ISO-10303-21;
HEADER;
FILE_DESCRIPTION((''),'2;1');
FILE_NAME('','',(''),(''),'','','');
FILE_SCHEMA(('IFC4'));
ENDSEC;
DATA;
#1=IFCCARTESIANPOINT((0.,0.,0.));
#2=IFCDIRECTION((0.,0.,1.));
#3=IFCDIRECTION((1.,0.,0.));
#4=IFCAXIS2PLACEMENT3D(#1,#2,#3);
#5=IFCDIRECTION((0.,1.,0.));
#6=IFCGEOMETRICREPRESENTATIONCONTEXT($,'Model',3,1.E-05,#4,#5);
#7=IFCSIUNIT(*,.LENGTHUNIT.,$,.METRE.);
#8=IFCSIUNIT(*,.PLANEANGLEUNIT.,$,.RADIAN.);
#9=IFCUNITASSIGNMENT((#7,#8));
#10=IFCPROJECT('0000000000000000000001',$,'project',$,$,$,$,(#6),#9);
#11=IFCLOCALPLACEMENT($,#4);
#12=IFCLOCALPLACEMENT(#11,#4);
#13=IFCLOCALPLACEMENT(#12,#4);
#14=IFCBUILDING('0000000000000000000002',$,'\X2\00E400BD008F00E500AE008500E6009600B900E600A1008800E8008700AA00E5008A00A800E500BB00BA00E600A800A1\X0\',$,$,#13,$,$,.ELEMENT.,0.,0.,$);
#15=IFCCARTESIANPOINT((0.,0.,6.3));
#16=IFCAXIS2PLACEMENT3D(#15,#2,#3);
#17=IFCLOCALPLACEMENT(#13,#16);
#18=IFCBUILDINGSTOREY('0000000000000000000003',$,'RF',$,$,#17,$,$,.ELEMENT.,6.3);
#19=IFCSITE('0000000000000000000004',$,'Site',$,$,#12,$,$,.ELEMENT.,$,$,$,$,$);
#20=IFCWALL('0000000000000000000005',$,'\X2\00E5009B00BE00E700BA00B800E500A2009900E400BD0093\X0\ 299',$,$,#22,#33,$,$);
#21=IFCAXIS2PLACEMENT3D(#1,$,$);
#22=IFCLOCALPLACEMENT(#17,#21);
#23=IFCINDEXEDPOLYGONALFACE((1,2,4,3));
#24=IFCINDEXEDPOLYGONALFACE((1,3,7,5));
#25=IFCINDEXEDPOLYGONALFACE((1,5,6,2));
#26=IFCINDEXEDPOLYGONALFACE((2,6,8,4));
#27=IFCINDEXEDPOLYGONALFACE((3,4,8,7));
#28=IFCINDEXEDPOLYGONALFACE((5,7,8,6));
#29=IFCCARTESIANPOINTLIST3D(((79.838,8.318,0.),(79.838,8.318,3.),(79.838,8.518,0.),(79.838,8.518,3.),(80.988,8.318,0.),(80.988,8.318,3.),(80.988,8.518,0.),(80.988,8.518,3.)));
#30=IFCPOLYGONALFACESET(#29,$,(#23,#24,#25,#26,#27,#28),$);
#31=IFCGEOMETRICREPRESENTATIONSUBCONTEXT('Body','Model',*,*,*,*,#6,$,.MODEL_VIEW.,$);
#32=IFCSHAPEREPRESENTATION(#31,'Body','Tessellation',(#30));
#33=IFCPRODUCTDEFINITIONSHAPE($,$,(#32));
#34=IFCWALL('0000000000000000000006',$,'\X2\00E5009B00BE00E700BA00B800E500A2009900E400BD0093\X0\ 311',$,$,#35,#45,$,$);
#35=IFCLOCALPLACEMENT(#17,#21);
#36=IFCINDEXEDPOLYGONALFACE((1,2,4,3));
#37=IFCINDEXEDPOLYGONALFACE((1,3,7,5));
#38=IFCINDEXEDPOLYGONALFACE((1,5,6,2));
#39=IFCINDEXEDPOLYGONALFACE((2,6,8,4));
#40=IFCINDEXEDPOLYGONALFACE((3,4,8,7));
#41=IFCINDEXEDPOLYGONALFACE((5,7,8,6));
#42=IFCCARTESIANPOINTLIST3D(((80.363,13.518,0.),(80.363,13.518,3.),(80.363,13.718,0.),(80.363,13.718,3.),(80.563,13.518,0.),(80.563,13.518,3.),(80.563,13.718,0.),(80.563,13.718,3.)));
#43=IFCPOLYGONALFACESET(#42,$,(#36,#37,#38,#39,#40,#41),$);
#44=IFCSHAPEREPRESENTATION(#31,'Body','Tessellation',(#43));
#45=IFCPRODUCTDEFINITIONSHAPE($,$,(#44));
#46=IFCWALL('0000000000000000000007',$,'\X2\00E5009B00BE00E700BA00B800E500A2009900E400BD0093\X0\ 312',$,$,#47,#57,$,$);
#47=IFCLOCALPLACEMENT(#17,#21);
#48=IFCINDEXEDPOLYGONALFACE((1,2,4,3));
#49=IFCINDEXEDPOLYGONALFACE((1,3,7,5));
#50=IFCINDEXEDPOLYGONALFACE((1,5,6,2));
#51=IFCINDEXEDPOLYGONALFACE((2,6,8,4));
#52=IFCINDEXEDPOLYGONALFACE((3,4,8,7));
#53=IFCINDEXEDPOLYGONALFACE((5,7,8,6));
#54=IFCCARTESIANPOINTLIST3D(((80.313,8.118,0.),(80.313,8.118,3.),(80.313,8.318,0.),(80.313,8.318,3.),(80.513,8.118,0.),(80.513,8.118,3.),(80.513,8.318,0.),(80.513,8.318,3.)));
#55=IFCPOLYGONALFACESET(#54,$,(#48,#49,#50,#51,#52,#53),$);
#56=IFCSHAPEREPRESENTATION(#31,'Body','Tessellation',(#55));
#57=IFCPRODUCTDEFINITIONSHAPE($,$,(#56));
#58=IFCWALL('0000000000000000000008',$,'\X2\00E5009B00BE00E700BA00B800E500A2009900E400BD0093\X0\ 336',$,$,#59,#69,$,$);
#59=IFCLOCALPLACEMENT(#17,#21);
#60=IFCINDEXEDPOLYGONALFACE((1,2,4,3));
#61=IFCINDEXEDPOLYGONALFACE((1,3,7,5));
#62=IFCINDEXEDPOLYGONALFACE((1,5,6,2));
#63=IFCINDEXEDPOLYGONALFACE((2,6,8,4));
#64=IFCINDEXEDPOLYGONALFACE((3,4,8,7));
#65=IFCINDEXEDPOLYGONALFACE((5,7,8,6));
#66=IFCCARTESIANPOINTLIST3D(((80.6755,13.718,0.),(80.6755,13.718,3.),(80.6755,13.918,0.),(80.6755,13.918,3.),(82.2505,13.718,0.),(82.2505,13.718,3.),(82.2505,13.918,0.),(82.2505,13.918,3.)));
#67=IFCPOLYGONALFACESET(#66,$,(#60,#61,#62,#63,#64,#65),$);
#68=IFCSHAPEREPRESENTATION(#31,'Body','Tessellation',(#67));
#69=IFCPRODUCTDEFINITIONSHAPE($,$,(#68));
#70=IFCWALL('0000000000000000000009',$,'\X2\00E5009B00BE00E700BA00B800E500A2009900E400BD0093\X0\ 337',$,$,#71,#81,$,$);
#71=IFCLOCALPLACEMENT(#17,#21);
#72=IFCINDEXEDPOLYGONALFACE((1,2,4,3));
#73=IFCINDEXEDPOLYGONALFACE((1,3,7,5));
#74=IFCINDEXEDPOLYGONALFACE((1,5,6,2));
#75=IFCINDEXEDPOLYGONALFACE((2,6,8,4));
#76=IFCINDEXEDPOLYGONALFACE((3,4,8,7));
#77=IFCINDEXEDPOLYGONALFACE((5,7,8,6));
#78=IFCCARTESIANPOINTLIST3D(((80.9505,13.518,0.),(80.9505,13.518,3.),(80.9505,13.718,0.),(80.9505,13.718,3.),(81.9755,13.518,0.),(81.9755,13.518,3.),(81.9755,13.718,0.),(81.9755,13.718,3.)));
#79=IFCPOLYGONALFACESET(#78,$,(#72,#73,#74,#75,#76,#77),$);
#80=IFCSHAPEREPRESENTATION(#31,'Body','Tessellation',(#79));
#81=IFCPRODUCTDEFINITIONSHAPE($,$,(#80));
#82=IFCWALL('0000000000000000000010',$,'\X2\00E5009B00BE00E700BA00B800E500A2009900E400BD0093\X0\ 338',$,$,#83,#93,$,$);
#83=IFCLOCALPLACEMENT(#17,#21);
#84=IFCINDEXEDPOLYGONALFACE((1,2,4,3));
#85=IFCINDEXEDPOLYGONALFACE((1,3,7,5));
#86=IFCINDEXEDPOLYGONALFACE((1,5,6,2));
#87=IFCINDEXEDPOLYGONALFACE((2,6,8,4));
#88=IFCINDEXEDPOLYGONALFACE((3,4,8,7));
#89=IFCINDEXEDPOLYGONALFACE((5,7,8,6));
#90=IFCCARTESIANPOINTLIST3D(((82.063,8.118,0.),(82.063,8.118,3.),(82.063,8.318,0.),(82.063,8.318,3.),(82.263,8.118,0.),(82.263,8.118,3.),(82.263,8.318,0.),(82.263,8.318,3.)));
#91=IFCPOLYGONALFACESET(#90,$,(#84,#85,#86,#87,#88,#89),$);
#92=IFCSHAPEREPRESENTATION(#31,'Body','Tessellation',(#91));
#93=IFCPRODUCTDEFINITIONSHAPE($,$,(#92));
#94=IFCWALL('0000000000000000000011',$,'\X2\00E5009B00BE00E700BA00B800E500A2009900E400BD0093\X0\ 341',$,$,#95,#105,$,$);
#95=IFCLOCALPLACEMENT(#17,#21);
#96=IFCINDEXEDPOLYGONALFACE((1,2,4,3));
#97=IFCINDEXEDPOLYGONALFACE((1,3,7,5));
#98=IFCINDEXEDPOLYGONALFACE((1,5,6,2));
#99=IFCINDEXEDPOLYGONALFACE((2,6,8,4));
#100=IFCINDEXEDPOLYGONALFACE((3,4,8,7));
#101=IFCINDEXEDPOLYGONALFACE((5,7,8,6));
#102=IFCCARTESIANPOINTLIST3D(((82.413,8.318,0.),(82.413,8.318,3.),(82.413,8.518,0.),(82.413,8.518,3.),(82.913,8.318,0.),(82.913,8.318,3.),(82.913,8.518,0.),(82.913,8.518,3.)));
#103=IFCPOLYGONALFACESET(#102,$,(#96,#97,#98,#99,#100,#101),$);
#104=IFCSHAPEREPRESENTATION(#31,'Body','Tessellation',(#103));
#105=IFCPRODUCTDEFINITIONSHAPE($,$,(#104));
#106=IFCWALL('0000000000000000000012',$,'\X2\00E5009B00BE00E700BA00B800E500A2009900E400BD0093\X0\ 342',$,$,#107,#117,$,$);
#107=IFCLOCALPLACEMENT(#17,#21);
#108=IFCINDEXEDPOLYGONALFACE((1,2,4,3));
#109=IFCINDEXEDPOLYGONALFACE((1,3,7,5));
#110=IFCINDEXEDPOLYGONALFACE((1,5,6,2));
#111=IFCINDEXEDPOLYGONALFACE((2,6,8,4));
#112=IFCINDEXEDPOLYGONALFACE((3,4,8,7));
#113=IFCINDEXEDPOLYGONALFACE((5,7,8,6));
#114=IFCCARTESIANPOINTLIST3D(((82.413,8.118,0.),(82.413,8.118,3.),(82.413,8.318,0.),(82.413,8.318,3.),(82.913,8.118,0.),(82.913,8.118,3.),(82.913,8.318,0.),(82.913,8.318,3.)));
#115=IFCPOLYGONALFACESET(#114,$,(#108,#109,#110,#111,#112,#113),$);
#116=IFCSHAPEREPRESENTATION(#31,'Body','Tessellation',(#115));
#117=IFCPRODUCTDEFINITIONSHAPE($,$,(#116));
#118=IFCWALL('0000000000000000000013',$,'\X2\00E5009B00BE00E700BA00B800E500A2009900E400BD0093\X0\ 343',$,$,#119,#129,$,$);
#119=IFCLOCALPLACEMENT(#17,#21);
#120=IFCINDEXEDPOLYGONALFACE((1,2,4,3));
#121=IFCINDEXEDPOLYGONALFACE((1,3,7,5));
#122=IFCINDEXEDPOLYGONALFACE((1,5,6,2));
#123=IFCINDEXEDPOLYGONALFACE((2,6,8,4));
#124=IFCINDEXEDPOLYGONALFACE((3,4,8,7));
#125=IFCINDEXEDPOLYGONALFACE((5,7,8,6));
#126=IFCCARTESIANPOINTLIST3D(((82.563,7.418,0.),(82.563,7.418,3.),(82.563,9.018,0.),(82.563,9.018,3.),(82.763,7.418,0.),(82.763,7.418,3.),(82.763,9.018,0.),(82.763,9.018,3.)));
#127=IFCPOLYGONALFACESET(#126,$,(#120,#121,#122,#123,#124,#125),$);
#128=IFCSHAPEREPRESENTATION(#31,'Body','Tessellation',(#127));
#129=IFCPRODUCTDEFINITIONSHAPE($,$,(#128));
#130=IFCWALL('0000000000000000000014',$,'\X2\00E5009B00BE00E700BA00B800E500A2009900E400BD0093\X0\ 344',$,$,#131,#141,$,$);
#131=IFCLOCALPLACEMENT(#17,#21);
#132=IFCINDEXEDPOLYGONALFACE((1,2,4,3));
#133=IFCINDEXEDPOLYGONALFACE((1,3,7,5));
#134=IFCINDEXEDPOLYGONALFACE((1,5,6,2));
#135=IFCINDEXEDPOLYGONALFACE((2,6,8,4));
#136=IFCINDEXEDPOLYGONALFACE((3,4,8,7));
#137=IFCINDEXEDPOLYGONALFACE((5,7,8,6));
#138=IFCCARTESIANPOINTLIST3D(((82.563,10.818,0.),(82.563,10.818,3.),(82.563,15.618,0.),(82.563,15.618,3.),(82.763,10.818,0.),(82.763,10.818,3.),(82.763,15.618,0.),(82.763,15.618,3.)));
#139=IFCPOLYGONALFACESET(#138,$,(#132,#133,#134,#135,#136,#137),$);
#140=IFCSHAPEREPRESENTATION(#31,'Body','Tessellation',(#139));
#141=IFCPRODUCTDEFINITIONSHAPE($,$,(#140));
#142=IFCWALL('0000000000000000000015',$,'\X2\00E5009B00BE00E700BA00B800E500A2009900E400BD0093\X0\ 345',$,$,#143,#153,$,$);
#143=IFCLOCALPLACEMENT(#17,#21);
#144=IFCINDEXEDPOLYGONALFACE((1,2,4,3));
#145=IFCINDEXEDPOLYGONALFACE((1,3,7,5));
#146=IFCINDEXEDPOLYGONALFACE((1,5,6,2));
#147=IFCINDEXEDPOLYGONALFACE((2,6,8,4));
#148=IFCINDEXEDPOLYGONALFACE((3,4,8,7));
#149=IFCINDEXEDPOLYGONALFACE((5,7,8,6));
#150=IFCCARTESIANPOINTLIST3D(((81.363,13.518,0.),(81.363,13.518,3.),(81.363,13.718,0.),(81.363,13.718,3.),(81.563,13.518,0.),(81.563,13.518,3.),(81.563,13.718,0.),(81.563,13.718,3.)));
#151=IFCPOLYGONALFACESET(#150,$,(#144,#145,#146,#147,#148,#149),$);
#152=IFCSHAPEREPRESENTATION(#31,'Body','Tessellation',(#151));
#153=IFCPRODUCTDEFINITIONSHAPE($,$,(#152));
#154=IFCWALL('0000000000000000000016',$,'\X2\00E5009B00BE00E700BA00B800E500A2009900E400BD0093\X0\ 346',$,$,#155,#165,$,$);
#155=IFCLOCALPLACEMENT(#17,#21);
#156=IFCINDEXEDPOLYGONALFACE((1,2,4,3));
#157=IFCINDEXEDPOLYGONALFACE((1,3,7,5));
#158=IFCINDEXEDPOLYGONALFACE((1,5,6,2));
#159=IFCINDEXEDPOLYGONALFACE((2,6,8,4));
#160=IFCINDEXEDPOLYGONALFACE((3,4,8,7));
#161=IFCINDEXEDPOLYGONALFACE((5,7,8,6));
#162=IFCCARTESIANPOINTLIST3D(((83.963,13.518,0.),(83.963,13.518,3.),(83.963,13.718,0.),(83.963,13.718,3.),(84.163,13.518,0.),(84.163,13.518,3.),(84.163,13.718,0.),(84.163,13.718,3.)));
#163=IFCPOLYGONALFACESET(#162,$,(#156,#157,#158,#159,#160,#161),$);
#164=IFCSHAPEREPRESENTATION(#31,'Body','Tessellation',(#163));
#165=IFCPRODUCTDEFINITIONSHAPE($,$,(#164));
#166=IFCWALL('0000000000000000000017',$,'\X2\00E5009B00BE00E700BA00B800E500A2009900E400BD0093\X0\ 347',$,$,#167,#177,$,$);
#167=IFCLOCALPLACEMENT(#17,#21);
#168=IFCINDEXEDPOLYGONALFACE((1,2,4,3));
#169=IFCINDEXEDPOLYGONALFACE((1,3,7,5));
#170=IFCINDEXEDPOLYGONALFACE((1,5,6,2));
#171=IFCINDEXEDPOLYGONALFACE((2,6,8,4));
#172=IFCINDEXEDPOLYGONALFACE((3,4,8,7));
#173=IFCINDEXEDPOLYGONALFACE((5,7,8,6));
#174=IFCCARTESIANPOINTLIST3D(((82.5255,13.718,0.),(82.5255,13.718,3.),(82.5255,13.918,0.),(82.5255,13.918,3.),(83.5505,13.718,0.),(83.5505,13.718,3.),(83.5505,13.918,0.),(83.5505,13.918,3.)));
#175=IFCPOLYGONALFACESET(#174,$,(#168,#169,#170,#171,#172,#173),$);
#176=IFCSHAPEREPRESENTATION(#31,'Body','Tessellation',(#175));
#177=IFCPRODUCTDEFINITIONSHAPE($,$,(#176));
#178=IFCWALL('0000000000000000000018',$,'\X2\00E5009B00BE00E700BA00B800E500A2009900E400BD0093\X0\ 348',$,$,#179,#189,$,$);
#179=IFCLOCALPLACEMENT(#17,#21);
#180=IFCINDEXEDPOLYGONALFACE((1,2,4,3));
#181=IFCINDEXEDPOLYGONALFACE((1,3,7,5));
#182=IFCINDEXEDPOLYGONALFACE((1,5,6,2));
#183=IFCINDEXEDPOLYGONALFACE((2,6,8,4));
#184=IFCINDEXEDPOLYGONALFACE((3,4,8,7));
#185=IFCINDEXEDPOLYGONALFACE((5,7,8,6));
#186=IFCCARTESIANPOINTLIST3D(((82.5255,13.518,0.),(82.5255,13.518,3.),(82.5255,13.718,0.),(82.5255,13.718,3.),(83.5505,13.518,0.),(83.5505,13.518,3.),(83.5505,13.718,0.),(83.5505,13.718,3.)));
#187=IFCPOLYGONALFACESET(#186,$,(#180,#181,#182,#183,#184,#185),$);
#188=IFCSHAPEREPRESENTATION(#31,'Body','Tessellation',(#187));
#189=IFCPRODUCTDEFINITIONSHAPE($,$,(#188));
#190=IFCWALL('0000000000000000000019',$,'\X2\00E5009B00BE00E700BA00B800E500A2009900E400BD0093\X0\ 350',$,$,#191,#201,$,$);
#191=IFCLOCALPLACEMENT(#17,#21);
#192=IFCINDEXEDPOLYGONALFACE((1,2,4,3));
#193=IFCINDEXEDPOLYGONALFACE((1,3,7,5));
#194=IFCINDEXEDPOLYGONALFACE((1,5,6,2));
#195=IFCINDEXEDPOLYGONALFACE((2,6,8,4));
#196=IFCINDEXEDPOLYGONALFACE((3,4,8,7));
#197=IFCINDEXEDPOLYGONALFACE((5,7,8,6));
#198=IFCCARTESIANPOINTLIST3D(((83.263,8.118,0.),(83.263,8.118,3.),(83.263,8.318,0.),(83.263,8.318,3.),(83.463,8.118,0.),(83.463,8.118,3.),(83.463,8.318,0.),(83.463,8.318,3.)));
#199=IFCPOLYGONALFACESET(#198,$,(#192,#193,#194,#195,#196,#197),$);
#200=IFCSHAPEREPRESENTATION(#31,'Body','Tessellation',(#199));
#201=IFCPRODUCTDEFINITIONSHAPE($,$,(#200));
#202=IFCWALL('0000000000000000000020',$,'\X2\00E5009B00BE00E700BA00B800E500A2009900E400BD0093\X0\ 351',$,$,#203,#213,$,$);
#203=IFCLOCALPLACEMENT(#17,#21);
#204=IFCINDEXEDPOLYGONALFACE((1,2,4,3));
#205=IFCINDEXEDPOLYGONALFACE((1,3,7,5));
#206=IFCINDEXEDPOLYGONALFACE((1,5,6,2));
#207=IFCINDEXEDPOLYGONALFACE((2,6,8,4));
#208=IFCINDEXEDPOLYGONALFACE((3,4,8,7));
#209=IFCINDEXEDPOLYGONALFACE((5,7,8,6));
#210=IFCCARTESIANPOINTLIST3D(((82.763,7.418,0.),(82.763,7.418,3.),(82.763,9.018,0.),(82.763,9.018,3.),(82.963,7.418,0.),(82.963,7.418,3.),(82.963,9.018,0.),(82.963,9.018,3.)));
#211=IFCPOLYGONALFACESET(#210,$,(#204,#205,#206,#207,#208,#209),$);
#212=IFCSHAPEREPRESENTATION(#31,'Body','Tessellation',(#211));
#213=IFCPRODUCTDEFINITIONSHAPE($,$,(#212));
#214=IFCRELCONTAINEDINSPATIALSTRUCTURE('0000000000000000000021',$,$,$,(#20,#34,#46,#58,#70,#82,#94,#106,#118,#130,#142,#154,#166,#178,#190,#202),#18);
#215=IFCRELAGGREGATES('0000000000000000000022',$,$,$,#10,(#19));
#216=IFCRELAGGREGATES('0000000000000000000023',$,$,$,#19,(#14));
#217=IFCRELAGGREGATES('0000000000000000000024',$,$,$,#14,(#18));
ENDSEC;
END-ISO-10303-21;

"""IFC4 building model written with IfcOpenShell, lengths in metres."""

from ifc_helpers import new_model, si_unit, direction, frame, frame_2d, origin_with_axes, place, context, subcontext, project, spatial, rectangle, extrude, element, save


model = new_model("IFC4")

# Units and contexts
model_context = context("Model", 3, precision=1e-05, world=origin_with_axes(), true_north=direction((0.0, 1.0, 0.0)))
body_context = subcontext(model_context, "Body", "Model", "MODEL_VIEW")
ifc_project = project(units=[si_unit("LENGTHUNIT", "METRE"), si_unit("PLANEANGLEUNIT", "RADIAN")], contexts=[model_context])

# Site, building, storey
placement = place(None, origin_with_axes())
site_placement = place(placement, origin_with_axes())
site = spatial("IfcSite", under=ifc_project, at=site_placement, Name="Site", CompositionType="ELEMENT")
building_placement = place(site_placement, origin_with_axes())
building = spatial("IfcBuilding", under=site, at=building_placement, Name="ä½\u008få®\u0085æ\u0096¹æ¡\u0088è\u0087ªå\u008a¨å»ºæ¨¡", CompositionType="ELEMENT", ElevationOfRefHeight=0.0, ElevationOfTerrain=0.0)
storey_placement = place(building_placement, frame((0.0, 0.0, 6.3), z_axis=(0.0, 0.0, 1.0), x_axis=(1.0, 0.0, 0.0)))
storey = spatial("IfcBuildingStorey", under=building, at=storey_placement, Name="RF", CompositionType="ELEMENT", Elevation=6.3)

# Walls
wall_1_placement = place(storey_placement, frame((80.413, 8.418, 0.0), z_axis=(0.0, 0.0, 1.0), x_axis=(-1.0, 0.0, 0.0)))
element("IfcWall", 1, at=wall_1_placement, inside=storey, Name="å\u009b¾çº¸å¢\u0099ä½\u0093 299", context=body_context, shape_type="SweptSolid", body=[
    extrude(rectangle(XDim=1.15, YDim=0.2, at=frame_2d((0.0, 0.0), x_axis=(1.0, 0.0, 0.0))), frame((0.0, 0.0, 0.0), z_axis=(0.0, 0.0, 1.0)), (0.0, 0.0, 1.0), 3.0),
])
for number, where, z_axis, x_axis, name in (
    (2, (80.463, 13.618, 0.0), (0.0, 0.0, 1.0), (0.0, 1.0, 0.0), "å\u009b¾çº¸å¢\u0099ä½\u0093 311"),
    (3, (80.413, 8.218, 0.0), (0.0, 0.0, 1.0), (0.0, 1.0, 0.0), "å\u009b¾çº¸å¢\u0099ä½\u0093 312"),
):
    element("IfcWall", number, at=place(storey_placement, frame(where, z_axis=z_axis, x_axis=x_axis)), inside=storey, Name=name, context=body_context, shape_type="SweptSolid", body=[
        extrude(rectangle(XDim=0.2, YDim=0.2, at=frame_2d((0.0, 0.0), x_axis=(1.0, 0.0, 0.0))), frame((0.0, 0.0, 0.0), z_axis=(0.0, 0.0, 1.0)), (0.0, 0.0, 1.0), 3.0),
    ])
wall_2_placement = place(storey_placement, frame((81.463, 13.818, 0.0), z_axis=(0.0, 0.0, 1.0), x_axis=(1.0, 0.0, 0.0)))
element("IfcWall", 4, at=wall_2_placement, inside=storey, Name="å\u009b¾çº¸å¢\u0099ä½\u0093 336", context=body_context, shape_type="SweptSolid", body=[
    extrude(rectangle(XDim=1.575, YDim=0.2, at=frame_2d((0.0, 0.0), x_axis=(1.0, 0.0, 0.0))), frame((0.0, 0.0, 0.0), z_axis=(0.0, 0.0, 1.0)), (0.0, 0.0, 1.0), 3.0),
])
wall_3_placement = place(storey_placement, frame((81.463, 13.618, 0.0), z_axis=(0.0, 0.0, 1.0), x_axis=(1.0, 0.0, 0.0)))
element("IfcWall", 5, at=wall_3_placement, inside=storey, Name="å\u009b¾çº¸å¢\u0099ä½\u0093 337", context=body_context, shape_type="SweptSolid", body=[
    extrude(rectangle(XDim=1.025, YDim=0.2, at=frame_2d((0.0, 0.0), x_axis=(1.0, 0.0, 0.0))), frame((0.0, 0.0, 0.0), z_axis=(0.0, 0.0, 1.0)), (0.0, 0.0, 1.0), 3.0),
])
wall_4_placement = place(storey_placement, frame((82.163, 8.218, 0.0), z_axis=(0.0, 0.0, 1.0), x_axis=(0.0, 1.0, 0.0)))
element("IfcWall", 6, at=wall_4_placement, inside=storey, Name="å\u009b¾çº¸å¢\u0099ä½\u0093 338", context=body_context, shape_type="SweptSolid", body=[
    extrude(rectangle(XDim=0.2, YDim=0.2, at=frame_2d((0.0, 0.0), x_axis=(1.0, 0.0, 0.0))), frame((0.0, 0.0, 0.0), z_axis=(0.0, 0.0, 1.0)), (0.0, 0.0, 1.0), 3.0),
])
for number, where, z_axis, x_axis, name in (
    (7, (82.663, 8.418, 0.0), (0.0, 0.0, 1.0), (-1.0, 0.0, 0.0), "å\u009b¾çº¸å¢\u0099ä½\u0093 341"),
    (8, (82.663, 8.218, 0.0), (0.0, 0.0, 1.0), (-1.0, 0.0, 0.0), "å\u009b¾çº¸å¢\u0099ä½\u0093 342"),
):
    element("IfcWall", number, at=place(storey_placement, frame(where, z_axis=z_axis, x_axis=x_axis)), inside=storey, Name=name, context=body_context, shape_type="SweptSolid", body=[
        extrude(rectangle(XDim=0.5, YDim=0.2, at=frame_2d((0.0, 0.0), x_axis=(1.0, 0.0, 0.0))), frame((0.0, 0.0, 0.0), z_axis=(0.0, 0.0, 1.0)), (0.0, 0.0, 1.0), 3.0),
    ])
wall_5_placement = place(storey_placement, frame((82.663, 8.218, 0.0), z_axis=(0.0, 0.0, 1.0), x_axis=(0.0, -1.0, 0.0)))
element("IfcWall", 9, at=wall_5_placement, inside=storey, Name="å\u009b¾çº¸å¢\u0099ä½\u0093 343", context=body_context, shape_type="SweptSolid", body=[
    extrude(rectangle(XDim=1.6, YDim=0.2, at=frame_2d((0.0, 0.0), x_axis=(1.0, 0.0, 0.0))), frame((0.0, 0.0, 0.0), z_axis=(0.0, 0.0, 1.0)), (0.0, 0.0, 1.0), 3.0),
])
wall_6_placement = place(storey_placement, frame((82.663, 13.218, 0.0), z_axis=(0.0, 0.0, 1.0), x_axis=(0.0, -1.0, 0.0)))
element("IfcWall", 10, at=wall_6_placement, inside=storey, Name="å\u009b¾çº¸å¢\u0099ä½\u0093 344", context=body_context, shape_type="SweptSolid", body=[
    extrude(rectangle(XDim=4.8, YDim=0.2, at=frame_2d((0.0, 0.0), x_axis=(1.0, 0.0, 0.0))), frame((0.0, 0.0, 0.0), z_axis=(0.0, 0.0, 1.0)), (0.0, 0.0, 1.0), 3.0),
])
for number, where, z_axis, x_axis, name in (
    (11, (81.463, 13.618, 0.0), (0.0, 0.0, 1.0), (0.0, 1.0, 0.0), "å\u009b¾çº¸å¢\u0099ä½\u0093 345"),
    (12, (84.063, 13.618, 0.0), (0.0, 0.0, 1.0), (0.0, 1.0, 0.0), "å\u009b¾çº¸å¢\u0099ä½\u0093 346"),
):
    element("IfcWall", number, at=place(storey_placement, frame(where, z_axis=z_axis, x_axis=x_axis)), inside=storey, Name=name, context=body_context, shape_type="SweptSolid", body=[
        extrude(rectangle(XDim=0.2, YDim=0.2, at=frame_2d((0.0, 0.0), x_axis=(1.0, 0.0, 0.0))), frame((0.0, 0.0, 0.0), z_axis=(0.0, 0.0, 1.0)), (0.0, 0.0, 1.0), 3.0),
    ])
for number, where, z_axis, x_axis, name in (
    (13, (83.038, 13.818, 0.0), (0.0, 0.0, 1.0), (1.0, 0.0, 0.0), "å\u009b¾çº¸å¢\u0099ä½\u0093 347"),
    (14, (83.038, 13.618, 0.0), (0.0, 0.0, 1.0), (1.0, 0.0, 0.0), "å\u009b¾çº¸å¢\u0099ä½\u0093 348"),
):
    element("IfcWall", number, at=place(storey_placement, frame(where, z_axis=z_axis, x_axis=x_axis)), inside=storey, Name=name, context=body_context, shape_type="SweptSolid", body=[
        extrude(rectangle(XDim=1.025, YDim=0.2, at=frame_2d((0.0, 0.0), x_axis=(1.0, 0.0, 0.0))), frame((0.0, 0.0, 0.0), z_axis=(0.0, 0.0, 1.0)), (0.0, 0.0, 1.0), 3.0),
    ])
wall_7_placement = place(storey_placement, frame((83.363, 8.218, 0.0), z_axis=(0.0, 0.0, 1.0), x_axis=(0.0, 1.0, 0.0)))
element("IfcWall", 15, at=wall_7_placement, inside=storey, Name="å\u009b¾çº¸å¢\u0099ä½\u0093 350", context=body_context, shape_type="SweptSolid", body=[
    extrude(rectangle(XDim=0.2, YDim=0.2, at=frame_2d((0.0, 0.0), x_axis=(1.0, 0.0, 0.0))), frame((0.0, 0.0, 0.0), z_axis=(0.0, 0.0, 1.0)), (0.0, 0.0, 1.0), 3.0),
])
wall_8_placement = place(storey_placement, frame((82.863, 8.218, 0.0), z_axis=(0.0, 0.0, 1.0), x_axis=(0.0, -1.0, 0.0)))
element("IfcWall", 16, at=wall_8_placement, inside=storey, Name="å\u009b¾çº¸å¢\u0099ä½\u0093 351", context=body_context, shape_type="SweptSolid", body=[
    extrude(rectangle(XDim=1.6, YDim=0.2, at=frame_2d((0.0, 0.0), x_axis=(1.0, 0.0, 0.0))), frame((0.0, 0.0, 0.0), z_axis=(0.0, 0.0, 1.0)), (0.0, 0.0, 1.0), 3.0),
])

save(model, "model.ifc")
